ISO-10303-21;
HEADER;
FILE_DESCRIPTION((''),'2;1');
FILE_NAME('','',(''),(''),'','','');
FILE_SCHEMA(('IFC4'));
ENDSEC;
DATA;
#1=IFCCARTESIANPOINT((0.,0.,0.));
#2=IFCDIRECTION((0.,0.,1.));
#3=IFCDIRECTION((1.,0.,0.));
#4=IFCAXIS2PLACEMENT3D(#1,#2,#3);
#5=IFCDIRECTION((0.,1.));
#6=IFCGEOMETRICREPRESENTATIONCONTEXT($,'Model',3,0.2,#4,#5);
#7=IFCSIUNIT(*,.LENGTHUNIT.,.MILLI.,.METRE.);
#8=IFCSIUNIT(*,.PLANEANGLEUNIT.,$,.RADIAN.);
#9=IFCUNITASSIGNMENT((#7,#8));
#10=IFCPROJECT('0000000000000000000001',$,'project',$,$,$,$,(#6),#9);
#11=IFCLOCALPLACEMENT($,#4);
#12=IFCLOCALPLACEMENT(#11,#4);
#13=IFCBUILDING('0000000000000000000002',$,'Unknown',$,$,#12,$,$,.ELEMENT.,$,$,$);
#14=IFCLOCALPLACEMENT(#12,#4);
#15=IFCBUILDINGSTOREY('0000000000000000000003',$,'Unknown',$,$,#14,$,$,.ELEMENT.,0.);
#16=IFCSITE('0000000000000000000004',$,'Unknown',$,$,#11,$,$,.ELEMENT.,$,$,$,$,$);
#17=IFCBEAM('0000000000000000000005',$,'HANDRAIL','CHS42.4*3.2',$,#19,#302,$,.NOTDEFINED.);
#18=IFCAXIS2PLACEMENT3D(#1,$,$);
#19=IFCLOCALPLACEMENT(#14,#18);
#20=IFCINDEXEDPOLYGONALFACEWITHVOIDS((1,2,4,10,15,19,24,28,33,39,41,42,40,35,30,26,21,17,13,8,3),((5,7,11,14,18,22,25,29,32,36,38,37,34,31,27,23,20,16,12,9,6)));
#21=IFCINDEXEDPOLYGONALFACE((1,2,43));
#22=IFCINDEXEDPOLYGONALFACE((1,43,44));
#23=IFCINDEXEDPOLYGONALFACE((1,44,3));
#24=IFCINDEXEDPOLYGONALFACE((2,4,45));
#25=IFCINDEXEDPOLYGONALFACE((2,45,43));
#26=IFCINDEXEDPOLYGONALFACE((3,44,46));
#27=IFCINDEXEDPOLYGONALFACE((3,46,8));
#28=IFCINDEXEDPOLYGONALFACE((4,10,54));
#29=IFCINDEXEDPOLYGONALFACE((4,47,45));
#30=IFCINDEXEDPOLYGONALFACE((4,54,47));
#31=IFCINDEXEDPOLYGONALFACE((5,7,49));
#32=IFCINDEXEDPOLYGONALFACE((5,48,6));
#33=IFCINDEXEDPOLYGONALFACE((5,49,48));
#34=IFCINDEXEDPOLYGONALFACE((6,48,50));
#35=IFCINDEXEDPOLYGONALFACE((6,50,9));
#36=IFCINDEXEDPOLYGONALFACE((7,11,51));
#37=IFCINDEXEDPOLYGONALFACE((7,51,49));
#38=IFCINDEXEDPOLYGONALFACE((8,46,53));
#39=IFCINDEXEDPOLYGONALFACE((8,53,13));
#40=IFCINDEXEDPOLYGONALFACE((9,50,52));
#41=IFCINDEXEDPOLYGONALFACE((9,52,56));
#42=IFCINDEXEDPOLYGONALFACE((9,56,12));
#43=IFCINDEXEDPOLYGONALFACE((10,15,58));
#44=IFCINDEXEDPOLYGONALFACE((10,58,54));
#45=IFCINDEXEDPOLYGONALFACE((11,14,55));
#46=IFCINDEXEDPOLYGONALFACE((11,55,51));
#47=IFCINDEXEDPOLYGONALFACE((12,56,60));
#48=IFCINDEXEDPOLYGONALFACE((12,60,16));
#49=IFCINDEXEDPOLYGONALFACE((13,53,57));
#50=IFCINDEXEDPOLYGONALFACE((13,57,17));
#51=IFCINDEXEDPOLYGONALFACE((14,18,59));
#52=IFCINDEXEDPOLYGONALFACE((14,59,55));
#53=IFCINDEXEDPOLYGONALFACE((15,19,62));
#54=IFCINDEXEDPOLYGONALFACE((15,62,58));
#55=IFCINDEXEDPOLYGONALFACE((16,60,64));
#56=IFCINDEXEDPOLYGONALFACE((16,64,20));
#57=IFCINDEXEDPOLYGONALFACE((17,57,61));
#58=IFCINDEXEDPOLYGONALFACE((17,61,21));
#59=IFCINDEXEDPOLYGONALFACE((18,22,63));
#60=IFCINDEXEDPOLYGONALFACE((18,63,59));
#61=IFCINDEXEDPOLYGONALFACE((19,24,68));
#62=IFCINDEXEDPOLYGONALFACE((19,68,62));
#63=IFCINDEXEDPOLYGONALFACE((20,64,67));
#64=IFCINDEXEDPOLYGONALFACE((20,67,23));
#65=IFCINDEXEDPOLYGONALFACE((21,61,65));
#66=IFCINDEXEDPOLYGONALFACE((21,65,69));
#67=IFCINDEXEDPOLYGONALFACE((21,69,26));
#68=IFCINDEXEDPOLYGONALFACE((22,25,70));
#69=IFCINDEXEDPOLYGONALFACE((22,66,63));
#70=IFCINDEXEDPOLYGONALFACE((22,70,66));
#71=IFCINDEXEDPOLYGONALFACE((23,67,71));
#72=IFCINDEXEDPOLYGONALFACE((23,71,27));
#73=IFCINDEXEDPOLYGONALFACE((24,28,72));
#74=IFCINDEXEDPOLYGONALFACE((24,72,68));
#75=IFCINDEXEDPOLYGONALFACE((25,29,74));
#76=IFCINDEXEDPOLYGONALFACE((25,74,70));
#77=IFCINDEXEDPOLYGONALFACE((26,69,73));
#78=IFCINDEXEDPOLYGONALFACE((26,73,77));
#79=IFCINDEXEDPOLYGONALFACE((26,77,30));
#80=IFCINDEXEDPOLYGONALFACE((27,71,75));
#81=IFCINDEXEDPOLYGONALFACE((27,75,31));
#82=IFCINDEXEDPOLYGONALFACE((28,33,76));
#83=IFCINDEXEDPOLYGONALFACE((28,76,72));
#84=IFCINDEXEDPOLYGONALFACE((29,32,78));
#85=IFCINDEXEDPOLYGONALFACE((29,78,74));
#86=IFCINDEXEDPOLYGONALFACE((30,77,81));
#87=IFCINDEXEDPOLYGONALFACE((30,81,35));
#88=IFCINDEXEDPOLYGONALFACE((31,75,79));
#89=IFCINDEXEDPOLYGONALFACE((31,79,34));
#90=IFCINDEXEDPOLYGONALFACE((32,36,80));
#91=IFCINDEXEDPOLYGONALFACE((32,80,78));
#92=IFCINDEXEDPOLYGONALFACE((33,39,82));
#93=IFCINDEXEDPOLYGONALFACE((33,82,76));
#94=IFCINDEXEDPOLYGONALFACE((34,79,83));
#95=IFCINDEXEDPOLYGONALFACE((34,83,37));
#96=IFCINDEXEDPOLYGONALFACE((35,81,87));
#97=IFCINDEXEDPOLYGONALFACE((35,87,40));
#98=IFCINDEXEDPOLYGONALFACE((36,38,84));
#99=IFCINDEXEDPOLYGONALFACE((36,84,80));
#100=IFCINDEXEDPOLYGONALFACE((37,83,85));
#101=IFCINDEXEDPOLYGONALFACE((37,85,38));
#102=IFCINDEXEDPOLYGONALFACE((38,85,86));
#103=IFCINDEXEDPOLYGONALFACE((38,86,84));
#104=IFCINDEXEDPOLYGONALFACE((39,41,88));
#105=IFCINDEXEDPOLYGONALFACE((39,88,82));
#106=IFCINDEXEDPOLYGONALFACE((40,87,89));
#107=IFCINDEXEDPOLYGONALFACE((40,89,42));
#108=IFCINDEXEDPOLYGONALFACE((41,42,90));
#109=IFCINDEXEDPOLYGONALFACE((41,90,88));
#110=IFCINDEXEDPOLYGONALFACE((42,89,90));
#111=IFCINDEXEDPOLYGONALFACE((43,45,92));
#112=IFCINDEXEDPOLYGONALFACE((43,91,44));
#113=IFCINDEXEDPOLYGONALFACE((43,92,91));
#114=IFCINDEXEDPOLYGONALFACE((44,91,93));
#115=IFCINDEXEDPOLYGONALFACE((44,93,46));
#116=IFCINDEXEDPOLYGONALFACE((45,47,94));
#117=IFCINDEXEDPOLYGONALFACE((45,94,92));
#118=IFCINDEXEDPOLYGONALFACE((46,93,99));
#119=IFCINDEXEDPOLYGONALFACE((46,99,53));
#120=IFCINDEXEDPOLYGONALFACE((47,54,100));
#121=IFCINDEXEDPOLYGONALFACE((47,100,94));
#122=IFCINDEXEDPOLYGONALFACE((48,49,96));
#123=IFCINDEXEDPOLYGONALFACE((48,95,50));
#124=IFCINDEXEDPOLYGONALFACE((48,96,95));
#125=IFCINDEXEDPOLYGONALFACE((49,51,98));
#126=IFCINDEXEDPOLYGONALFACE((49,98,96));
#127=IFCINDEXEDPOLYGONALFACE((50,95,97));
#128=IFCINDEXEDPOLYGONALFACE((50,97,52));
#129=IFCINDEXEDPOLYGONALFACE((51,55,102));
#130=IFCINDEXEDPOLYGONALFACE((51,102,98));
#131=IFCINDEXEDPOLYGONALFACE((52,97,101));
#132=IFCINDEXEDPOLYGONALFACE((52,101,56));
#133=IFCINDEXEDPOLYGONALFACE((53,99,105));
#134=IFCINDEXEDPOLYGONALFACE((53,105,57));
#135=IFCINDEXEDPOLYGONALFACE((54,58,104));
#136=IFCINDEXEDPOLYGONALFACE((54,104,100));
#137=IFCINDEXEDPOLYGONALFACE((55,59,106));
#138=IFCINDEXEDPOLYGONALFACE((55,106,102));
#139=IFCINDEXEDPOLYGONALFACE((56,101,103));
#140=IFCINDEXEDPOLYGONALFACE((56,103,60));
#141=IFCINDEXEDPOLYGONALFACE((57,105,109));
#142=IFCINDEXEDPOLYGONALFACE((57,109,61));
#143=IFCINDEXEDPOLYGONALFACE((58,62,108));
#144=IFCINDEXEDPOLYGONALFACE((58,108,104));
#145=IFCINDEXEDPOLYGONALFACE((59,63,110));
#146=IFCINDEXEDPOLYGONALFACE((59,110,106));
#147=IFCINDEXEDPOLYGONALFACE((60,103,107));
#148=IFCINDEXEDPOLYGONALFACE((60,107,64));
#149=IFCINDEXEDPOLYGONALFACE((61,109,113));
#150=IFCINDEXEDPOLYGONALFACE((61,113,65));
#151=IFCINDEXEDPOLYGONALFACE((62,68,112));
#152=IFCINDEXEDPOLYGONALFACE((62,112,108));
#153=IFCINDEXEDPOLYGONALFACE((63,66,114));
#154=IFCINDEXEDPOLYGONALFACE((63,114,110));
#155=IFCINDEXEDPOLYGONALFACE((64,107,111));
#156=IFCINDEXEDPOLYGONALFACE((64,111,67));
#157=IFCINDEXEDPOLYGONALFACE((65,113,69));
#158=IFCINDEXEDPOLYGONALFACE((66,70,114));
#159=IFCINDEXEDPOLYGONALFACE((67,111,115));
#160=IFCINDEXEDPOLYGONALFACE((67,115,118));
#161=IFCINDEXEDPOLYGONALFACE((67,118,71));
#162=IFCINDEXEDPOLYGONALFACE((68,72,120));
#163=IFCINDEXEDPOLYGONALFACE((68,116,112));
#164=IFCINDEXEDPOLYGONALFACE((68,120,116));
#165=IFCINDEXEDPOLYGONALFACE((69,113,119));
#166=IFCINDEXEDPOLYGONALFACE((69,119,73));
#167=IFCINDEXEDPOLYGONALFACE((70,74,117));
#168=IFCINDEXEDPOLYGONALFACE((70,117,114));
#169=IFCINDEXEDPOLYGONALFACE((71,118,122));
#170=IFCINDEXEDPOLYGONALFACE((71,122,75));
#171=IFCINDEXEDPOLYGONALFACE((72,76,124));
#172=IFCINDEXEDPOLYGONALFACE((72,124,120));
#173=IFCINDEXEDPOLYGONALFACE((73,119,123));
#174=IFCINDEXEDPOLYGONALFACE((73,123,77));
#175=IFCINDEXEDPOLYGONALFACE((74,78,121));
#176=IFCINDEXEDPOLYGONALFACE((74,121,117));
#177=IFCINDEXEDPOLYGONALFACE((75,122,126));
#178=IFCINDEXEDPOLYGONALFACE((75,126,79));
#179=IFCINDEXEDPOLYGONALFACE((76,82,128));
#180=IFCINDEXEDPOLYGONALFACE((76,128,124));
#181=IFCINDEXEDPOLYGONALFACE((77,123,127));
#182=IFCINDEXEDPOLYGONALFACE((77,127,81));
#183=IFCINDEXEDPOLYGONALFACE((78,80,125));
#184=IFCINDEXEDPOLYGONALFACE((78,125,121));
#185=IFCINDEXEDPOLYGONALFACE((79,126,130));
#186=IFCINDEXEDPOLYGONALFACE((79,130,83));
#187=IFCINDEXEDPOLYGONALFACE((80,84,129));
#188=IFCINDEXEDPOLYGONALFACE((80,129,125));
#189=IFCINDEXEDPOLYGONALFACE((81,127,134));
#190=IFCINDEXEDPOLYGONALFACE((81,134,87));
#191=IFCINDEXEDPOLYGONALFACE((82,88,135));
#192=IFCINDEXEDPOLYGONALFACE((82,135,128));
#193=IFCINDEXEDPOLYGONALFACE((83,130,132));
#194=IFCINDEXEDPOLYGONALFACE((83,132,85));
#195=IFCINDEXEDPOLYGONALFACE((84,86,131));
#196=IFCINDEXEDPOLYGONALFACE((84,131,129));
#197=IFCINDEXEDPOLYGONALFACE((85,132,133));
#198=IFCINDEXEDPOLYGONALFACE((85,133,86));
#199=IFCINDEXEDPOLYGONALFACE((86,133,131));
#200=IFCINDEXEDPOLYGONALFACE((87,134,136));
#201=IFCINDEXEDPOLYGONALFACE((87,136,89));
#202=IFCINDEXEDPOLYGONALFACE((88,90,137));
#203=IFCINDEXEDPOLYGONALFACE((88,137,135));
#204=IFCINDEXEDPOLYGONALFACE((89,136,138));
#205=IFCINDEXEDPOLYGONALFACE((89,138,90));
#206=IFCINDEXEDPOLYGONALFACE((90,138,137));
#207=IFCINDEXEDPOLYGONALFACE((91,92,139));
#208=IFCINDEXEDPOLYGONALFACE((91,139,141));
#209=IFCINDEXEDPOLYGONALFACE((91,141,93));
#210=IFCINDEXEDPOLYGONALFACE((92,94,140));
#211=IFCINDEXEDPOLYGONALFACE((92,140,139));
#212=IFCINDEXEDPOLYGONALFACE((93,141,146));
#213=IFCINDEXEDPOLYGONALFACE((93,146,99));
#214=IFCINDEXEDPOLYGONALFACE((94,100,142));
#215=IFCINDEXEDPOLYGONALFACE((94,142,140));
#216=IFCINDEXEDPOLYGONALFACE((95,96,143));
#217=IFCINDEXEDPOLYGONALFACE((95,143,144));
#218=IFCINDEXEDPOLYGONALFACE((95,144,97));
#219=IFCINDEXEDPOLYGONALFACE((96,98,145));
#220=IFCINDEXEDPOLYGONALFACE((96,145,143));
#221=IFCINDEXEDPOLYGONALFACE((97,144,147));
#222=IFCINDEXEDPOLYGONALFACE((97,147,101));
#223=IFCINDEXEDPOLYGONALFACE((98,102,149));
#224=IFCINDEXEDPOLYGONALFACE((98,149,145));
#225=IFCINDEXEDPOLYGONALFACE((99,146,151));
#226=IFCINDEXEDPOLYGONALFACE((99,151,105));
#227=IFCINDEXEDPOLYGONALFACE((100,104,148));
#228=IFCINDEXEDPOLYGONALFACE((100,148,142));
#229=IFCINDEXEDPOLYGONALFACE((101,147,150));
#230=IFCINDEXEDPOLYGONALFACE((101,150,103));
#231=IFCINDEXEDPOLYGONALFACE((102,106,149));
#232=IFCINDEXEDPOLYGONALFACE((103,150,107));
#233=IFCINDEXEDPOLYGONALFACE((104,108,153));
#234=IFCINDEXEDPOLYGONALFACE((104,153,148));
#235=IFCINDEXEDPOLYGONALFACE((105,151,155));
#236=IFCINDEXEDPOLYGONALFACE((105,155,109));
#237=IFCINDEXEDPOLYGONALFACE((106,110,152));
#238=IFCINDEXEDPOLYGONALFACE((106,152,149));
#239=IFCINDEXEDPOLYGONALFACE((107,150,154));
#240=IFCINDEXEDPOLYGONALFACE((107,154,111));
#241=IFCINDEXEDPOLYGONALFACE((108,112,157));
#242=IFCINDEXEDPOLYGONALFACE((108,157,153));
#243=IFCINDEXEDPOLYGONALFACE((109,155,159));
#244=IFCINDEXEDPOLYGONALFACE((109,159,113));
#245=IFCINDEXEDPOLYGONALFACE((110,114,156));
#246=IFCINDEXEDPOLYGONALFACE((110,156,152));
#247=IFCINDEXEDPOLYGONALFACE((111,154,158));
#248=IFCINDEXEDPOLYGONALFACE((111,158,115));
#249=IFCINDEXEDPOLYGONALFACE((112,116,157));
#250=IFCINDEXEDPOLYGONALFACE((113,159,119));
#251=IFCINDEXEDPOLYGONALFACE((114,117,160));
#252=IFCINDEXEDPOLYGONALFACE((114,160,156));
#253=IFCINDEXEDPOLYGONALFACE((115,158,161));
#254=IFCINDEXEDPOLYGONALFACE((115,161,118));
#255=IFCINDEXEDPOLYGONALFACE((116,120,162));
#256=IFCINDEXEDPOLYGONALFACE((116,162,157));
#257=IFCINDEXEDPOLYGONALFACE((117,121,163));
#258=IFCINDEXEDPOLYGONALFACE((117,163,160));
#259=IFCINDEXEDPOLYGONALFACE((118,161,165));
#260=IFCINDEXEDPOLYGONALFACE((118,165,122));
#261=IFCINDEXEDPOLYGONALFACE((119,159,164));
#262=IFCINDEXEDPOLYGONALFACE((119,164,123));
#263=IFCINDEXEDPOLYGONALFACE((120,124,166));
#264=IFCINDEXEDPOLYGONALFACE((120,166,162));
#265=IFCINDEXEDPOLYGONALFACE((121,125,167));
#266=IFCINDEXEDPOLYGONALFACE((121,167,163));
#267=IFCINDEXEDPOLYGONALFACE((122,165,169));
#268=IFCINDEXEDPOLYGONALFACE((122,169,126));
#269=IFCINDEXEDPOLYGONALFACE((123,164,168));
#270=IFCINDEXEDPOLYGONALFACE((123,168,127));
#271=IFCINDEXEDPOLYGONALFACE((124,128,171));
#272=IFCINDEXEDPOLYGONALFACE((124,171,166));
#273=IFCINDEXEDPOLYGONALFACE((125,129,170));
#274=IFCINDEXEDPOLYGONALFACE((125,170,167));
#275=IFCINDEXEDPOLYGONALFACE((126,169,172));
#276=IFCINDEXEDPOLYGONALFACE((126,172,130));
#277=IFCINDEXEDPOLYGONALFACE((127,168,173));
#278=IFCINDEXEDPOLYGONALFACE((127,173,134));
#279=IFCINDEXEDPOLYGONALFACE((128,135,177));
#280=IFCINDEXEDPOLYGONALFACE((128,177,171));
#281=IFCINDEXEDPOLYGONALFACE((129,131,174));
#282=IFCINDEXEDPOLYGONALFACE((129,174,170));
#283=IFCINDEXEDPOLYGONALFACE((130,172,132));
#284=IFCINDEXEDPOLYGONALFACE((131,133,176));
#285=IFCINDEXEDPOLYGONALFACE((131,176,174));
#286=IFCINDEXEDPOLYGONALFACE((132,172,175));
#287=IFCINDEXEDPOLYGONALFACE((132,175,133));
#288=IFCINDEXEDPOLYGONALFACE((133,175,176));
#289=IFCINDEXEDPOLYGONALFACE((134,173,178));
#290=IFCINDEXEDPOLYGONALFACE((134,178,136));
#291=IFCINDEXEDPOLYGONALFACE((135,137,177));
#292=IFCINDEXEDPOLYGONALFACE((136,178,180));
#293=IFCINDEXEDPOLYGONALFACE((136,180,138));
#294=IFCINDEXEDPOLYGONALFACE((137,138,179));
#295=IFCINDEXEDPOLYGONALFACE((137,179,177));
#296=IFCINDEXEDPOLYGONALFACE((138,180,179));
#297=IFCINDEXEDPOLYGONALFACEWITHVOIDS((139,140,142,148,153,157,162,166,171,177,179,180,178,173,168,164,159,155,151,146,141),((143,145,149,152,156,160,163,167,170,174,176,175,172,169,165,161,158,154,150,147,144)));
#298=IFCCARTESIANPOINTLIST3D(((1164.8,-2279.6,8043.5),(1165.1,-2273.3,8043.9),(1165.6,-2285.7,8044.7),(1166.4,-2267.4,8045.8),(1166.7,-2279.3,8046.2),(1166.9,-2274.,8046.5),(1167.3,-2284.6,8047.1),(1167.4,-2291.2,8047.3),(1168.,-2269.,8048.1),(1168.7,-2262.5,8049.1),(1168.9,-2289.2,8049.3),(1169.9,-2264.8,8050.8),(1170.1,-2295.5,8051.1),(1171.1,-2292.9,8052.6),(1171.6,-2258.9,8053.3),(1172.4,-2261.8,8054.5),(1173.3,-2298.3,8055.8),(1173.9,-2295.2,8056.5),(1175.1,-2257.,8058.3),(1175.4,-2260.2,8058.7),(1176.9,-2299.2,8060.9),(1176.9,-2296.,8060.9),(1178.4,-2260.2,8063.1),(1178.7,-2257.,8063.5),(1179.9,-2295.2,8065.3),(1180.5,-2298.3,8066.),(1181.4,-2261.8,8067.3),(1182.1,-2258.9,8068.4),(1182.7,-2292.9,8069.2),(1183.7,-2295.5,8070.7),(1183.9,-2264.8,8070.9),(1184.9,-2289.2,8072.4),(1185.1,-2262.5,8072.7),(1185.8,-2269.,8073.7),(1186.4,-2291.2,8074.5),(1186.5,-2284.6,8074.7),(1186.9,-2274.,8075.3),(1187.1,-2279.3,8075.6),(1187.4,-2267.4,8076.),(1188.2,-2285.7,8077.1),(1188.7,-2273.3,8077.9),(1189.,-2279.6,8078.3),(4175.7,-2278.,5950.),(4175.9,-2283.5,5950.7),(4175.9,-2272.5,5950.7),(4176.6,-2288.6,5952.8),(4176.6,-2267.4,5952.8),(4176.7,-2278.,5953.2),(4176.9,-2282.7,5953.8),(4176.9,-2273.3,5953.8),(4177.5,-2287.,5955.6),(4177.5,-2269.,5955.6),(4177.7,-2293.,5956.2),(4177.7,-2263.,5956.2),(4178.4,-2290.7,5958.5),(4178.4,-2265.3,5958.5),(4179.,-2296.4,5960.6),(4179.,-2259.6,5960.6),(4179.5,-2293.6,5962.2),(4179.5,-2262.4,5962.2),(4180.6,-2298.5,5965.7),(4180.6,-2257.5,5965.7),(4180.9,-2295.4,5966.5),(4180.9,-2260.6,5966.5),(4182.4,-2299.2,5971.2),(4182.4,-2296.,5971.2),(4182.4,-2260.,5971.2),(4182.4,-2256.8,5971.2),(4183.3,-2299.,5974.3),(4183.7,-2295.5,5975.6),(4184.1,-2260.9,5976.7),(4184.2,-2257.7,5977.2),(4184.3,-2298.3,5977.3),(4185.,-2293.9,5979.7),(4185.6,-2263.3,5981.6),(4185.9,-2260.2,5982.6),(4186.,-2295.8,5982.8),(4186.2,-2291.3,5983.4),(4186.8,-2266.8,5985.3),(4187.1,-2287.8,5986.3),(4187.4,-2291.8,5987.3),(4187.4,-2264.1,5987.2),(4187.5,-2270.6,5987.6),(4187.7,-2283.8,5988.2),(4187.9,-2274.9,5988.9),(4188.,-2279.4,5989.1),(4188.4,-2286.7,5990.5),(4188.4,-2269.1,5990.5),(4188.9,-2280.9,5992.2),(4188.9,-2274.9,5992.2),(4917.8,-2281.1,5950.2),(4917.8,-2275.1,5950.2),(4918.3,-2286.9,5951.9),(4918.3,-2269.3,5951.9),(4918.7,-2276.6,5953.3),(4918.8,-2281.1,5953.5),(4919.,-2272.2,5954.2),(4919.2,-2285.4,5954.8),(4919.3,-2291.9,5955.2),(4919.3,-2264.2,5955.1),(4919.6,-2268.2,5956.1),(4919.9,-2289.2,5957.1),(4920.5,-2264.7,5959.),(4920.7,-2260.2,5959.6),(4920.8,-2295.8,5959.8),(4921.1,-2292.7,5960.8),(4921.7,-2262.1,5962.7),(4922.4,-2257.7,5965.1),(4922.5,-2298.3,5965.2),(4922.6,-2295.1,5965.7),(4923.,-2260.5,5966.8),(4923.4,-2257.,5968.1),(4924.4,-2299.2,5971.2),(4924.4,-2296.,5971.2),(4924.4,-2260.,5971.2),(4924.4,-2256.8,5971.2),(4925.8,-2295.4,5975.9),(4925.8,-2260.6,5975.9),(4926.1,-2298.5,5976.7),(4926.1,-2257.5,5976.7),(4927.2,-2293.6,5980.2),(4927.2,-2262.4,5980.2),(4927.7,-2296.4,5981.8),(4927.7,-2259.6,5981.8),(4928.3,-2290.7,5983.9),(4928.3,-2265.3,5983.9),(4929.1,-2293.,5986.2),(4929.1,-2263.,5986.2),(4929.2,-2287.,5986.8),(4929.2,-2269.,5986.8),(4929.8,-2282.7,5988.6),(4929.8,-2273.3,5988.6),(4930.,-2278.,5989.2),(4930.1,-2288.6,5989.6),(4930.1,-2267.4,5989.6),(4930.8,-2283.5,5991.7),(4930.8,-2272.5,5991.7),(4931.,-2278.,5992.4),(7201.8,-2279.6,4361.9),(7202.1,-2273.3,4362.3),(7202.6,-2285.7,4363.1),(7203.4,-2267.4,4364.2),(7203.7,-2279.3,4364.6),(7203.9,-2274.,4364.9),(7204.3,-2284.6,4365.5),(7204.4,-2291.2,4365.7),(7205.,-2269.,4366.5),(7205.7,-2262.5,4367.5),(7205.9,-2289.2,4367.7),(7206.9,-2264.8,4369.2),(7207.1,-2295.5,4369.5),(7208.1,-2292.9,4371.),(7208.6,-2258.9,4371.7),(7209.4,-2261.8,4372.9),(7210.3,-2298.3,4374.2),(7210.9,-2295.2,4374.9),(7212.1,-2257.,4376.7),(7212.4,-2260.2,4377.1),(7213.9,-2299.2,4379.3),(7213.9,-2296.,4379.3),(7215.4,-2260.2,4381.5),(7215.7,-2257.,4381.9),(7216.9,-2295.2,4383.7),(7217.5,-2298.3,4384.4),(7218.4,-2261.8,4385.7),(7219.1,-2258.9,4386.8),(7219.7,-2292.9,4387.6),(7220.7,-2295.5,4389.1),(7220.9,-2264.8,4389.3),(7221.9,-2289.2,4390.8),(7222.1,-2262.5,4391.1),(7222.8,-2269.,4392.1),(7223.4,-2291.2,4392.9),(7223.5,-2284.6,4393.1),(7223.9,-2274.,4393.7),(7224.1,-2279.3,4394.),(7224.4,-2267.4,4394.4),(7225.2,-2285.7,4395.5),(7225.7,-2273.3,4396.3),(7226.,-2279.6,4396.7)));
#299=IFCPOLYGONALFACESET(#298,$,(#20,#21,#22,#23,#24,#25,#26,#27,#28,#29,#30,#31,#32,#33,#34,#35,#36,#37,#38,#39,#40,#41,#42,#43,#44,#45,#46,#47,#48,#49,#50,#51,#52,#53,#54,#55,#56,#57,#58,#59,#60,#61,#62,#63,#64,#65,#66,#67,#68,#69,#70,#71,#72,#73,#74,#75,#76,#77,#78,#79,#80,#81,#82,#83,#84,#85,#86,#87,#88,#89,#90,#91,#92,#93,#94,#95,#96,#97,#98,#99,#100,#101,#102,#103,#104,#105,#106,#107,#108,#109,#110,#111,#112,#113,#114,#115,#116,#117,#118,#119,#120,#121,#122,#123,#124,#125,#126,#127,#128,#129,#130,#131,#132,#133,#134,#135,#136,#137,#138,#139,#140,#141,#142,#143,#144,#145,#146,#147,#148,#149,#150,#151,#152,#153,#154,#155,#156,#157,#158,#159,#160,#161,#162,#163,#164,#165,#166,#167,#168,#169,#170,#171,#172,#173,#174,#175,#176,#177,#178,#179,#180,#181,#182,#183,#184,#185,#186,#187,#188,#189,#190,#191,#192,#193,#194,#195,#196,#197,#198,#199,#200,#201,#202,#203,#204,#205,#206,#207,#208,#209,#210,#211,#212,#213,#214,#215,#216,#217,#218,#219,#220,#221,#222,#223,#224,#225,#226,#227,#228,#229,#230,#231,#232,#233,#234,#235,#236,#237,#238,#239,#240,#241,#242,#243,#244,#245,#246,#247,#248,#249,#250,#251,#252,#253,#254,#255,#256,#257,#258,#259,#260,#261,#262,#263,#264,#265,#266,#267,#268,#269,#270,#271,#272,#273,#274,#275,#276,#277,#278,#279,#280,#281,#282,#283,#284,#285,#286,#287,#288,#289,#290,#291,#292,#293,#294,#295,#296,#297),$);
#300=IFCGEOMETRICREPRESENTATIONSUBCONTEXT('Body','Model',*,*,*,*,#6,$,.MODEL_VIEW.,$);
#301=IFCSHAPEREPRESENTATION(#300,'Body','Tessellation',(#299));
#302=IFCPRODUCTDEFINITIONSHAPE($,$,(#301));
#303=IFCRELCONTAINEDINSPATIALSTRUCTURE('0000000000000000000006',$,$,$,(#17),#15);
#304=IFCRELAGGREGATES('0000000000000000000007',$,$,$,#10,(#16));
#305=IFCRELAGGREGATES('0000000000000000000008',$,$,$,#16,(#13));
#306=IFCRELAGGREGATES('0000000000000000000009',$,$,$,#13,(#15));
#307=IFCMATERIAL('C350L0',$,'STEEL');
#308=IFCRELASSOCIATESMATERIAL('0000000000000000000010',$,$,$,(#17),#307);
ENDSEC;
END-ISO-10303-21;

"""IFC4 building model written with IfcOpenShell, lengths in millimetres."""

from ifc_helpers import new_model, entity, si_unit, direction, frame, origin_with_axes, place, context, subcontext, project, spatial, material, element, save


model = new_model("IFC4")

# Units and contexts
model_context = context("Model", 3, precision=0.2, world=origin_with_axes(), true_north=direction((0.0, 1.0)))
body_context = subcontext(model_context, "Body", "Model", "MODEL_VIEW")
ifc_project = project(units=[si_unit("LENGTHUNIT", "METRE", prefix="MILLI"), si_unit("PLANEANGLEUNIT", "RADIAN")], contexts=[model_context])

# Site, building, storey
site_placement = place(None, origin_with_axes())
site = spatial("IfcSite", under=ifc_project, at=site_placement, Name="Unknown", CompositionType="ELEMENT")
building_placement = place(site_placement, origin_with_axes())
building = spatial("IfcBuilding", under=site, at=building_placement, Name="Unknown", CompositionType="ELEMENT")
storey_placement = place(building_placement, origin_with_axes())
storey = spatial("IfcBuildingStorey", under=building, at=storey_placement, Name="Unknown", CompositionType="ELEMENT", Elevation=0.0)

# Shared definitions
ifc_material_1 = material(Name="C350L0", Category="STEEL")

# Beam
for number, where, z_axis, x_axis, name in (
    (1, (1176.9, -2278.0, 8060.9), (0.0, -1.0, 0.0), (0.821041, 0.0, -0.57087), "HANDRAIL"),
):
    element("IfcBeam", number, at=place(storey_placement, frame(where, z_axis=z_axis, x_axis=x_axis)), inside=storey, material=ifc_material_1, Name=name, Description="CHS42.4*3.2", PredefinedType="NOTDEFINED", context=body_context, shape_type="SolidModel", body=[
        entity("IfcSweptDiskSolid", entity("IfcIndexedPolyCurve", entity("IfcCartesianPointList3D", [[0.0, 0.0, 0.0], [3660.5, 0.0, 0.0], [4269.8, 423.6, 0.0], [7058.3, 423.6, 0.0]]), [entity("IfcLineIndex", [1, 2, 3, 4])]), 21.2, 18.0),
    ])

save(model, "model.ifc")
